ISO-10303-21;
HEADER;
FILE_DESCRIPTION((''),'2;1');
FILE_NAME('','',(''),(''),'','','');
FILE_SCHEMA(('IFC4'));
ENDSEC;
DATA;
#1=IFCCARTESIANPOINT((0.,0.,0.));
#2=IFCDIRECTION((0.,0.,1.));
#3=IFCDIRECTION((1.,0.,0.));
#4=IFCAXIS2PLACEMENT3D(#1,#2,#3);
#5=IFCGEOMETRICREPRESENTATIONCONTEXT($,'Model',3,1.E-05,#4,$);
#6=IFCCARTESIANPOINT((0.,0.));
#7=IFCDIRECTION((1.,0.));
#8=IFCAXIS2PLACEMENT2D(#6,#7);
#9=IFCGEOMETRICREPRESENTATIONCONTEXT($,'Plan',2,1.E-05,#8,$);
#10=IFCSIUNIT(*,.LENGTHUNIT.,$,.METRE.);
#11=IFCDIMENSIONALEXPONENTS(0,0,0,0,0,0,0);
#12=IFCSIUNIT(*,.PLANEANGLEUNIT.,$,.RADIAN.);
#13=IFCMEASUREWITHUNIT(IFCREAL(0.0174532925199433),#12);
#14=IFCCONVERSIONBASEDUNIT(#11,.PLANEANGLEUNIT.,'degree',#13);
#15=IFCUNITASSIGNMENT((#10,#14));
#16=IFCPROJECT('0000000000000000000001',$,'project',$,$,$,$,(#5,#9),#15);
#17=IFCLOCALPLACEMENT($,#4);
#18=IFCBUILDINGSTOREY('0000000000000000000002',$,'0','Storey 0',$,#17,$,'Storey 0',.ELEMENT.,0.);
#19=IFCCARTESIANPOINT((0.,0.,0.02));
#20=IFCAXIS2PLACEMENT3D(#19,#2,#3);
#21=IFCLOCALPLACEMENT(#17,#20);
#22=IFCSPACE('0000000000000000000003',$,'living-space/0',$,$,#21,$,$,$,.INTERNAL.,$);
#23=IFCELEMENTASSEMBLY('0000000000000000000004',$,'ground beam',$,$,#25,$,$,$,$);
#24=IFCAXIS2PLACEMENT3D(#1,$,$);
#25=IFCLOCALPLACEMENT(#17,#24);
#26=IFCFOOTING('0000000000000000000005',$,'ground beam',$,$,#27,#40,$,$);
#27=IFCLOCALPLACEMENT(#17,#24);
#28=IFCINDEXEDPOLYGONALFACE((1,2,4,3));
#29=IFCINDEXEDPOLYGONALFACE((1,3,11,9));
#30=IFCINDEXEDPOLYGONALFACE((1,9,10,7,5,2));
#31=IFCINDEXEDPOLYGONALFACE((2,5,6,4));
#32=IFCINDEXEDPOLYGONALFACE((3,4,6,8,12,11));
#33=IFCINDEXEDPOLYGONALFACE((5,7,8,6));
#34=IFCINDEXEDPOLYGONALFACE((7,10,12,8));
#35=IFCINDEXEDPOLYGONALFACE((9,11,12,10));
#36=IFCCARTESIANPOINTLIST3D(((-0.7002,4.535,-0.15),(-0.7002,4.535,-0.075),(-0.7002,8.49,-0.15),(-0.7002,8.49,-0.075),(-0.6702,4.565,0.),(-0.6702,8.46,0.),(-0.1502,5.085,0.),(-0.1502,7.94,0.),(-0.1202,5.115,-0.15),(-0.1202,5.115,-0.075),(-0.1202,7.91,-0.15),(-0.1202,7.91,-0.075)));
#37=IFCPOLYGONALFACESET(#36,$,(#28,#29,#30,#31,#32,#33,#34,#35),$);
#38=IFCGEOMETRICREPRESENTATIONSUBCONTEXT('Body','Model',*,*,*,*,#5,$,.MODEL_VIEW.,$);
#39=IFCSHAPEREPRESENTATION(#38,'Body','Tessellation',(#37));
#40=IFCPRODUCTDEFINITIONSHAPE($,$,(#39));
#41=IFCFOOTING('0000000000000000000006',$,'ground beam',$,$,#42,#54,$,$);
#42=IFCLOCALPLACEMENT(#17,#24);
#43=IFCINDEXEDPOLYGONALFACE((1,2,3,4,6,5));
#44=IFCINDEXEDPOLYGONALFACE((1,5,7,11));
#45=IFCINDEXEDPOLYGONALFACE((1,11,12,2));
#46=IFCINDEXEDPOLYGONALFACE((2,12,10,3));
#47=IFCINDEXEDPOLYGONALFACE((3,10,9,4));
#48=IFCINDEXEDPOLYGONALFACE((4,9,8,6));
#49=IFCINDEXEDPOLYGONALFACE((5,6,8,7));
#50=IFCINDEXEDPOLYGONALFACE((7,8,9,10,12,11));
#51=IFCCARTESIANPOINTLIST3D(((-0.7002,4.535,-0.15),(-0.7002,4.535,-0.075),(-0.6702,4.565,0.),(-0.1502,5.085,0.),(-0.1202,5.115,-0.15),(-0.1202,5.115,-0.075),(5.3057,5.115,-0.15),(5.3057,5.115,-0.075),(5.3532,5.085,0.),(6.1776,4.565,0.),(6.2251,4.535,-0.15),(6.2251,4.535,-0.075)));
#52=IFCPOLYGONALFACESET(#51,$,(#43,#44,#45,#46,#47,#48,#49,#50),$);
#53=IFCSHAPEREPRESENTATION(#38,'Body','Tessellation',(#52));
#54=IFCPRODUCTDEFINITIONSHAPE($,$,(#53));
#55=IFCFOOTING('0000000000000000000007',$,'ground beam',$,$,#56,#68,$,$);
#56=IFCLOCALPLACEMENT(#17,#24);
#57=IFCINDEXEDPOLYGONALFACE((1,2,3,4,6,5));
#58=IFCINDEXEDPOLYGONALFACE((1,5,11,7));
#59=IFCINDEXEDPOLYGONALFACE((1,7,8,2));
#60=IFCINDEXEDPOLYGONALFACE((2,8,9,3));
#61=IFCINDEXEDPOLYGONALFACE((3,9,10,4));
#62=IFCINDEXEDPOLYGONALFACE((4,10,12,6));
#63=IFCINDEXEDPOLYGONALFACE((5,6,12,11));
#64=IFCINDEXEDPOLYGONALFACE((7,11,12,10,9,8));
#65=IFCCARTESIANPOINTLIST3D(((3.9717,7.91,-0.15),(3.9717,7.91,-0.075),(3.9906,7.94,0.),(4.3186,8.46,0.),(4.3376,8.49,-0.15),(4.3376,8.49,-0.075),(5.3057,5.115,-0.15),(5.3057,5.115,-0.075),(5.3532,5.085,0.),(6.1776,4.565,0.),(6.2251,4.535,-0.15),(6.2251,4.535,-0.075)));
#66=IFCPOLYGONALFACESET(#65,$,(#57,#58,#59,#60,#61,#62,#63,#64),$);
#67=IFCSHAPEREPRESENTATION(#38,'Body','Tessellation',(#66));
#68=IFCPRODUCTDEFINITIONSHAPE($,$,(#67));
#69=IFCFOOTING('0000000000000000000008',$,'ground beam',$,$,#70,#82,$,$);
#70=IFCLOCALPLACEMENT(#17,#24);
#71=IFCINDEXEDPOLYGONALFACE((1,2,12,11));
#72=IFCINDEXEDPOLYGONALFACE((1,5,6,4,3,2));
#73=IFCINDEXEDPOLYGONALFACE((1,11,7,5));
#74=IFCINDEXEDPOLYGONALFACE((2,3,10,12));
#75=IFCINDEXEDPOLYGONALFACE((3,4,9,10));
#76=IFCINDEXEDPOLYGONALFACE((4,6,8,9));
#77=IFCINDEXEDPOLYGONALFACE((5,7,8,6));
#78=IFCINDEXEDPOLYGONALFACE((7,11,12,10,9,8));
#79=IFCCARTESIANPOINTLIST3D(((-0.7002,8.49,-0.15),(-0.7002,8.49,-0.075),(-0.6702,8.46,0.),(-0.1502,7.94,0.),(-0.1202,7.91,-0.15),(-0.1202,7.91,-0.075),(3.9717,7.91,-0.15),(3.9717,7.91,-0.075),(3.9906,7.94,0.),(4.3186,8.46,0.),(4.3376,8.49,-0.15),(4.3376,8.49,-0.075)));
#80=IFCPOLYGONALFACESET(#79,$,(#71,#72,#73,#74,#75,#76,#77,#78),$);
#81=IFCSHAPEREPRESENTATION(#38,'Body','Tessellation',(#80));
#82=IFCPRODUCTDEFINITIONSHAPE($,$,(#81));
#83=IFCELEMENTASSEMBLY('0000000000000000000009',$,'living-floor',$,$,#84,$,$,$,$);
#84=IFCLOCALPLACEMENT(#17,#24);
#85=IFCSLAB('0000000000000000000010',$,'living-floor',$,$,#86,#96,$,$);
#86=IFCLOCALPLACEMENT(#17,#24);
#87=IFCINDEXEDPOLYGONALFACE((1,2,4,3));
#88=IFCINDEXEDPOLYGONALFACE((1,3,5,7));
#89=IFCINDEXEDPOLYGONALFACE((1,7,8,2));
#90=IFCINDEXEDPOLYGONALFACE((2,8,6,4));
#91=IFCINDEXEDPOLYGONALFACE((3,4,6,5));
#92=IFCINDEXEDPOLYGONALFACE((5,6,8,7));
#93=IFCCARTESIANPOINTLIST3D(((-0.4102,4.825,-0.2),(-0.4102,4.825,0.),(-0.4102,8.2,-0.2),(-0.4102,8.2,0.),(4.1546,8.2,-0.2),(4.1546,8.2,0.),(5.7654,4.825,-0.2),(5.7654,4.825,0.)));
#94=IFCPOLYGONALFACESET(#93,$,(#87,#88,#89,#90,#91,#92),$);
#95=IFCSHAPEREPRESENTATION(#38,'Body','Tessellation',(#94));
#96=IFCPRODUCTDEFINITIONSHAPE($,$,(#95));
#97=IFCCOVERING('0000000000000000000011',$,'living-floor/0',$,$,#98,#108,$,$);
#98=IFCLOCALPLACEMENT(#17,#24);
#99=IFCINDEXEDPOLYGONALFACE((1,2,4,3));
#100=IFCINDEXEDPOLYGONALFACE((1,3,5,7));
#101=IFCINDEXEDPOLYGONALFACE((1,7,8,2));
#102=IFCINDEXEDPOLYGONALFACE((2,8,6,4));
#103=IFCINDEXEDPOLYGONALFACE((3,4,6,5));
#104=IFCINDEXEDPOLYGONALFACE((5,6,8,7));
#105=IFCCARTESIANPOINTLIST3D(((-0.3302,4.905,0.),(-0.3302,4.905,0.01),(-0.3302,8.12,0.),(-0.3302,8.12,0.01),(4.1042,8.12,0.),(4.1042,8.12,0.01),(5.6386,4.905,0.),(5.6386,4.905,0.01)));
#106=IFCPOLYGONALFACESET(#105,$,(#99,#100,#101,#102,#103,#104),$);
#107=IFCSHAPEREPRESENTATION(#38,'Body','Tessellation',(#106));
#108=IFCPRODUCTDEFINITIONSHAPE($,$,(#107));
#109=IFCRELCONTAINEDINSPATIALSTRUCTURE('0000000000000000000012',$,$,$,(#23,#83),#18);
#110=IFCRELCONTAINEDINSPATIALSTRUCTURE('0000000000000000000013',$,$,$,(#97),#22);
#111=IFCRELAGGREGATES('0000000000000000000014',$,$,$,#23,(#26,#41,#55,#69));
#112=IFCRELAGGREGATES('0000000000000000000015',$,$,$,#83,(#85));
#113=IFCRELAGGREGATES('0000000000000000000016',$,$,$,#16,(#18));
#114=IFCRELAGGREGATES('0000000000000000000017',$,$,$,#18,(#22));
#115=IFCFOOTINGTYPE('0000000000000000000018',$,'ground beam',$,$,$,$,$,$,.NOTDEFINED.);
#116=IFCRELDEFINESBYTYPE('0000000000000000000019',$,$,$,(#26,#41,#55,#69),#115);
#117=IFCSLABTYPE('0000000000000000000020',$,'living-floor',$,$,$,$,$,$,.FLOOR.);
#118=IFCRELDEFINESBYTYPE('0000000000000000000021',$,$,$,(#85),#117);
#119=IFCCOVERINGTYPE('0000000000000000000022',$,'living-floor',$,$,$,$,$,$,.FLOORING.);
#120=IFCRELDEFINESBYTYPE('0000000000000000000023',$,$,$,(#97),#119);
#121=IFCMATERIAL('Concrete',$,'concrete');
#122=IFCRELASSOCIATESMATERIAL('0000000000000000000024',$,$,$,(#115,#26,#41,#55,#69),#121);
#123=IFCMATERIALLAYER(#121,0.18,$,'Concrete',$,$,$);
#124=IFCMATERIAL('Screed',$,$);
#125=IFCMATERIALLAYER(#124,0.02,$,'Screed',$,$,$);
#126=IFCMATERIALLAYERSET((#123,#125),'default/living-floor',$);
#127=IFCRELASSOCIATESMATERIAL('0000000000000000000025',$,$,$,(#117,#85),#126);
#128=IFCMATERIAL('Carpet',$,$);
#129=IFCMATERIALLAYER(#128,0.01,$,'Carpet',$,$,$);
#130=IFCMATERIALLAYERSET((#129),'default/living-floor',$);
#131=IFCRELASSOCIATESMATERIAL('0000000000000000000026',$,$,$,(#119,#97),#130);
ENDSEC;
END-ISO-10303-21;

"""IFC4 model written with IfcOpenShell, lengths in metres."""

from ifc_helpers import new_model, entity, si_unit, converted_unit, frame, origin, origin_with_axes, origin_2d_with_axis, place, context, subcontext, project, spatial, polyline, outline, extrude, clip, halfspace, material, layer, layer_set, layer_usage, material_profile, profile_set, profile_usage, type_object, element, aggregate, save


model = new_model("IFC4")

# Units and contexts
model_context = context("Model", 3, precision=1e-05, world=origin_with_axes())
plan_context = context("Plan", 2, precision=1e-05, world=origin_2d_with_axis())
body_context = subcontext(model_context, "Body", "Model", "MODEL_VIEW")
ifc_project = project(units=[si_unit("LENGTHUNIT", "METRE"), converted_unit("PLANEANGLEUNIT", "degree", entity("IfcReal", 0.0174532925199433), si_unit("PLANEANGLEUNIT", "RADIAN"), dimensions=[0, 0, 0, 0, 0, 0, 0])], contexts=[model_context, plan_context])

# Storey
storey_placement = place(None, origin_with_axes())
storey = spatial("IfcBuildingStorey", under=ifc_project, at=storey_placement, Name="0", Description="Storey 0", LongName="Storey 0", CompositionType="ELEMENT", Elevation=0.0)

# Element assembly, footings
assembly_1_placement = place(storey_placement, origin_with_axes())
assembly_1 = element("IfcElementAssembly", 1, at=assembly_1_placement, inside=storey, Name="ground beam")
ifc_material_1 = material(Name="Concrete", Category="concrete")
ifc_material_profile = material_profile(ifc_material_1, outline(polyline([(-0.26, 0.0), (-0.29, -0.075), (-0.29, -0.15), (0.29, -0.15), (0.29, -0.075), (0.26, 0.0), (-0.26, 0.0)])))
ifc_profile_set = profile_set([ifc_material_profile])
ifc_profile_usage_1 = profile_usage(ifc_profile_set)
footing_type = type_object("IfcFootingType", Name="ground beam", PredefinedType="NOTDEFINED", material=ifc_profile_set)
footing_1_placement = place(assembly_1_placement, frame((-0.4102, 3.825, 0.0), z_axis=(0.0, 1.0, 0.0), x_axis=(-1.0, 0.0, 0.0)))
footing_1 = element("IfcFooting", 2, at=footing_1_placement, type_object=footing_type, material=ifc_profile_usage_1, Name="ground beam", context=body_context, shape_type="Clipping", body=[
    clip(clip(extrude(outline(polyline([(-0.26, 0.0), (-0.29, -0.075), (-0.29, -0.15), (0.29, -0.15), (0.29, -0.075), (0.26, 0.0), (-0.26, 0.0)])), origin_with_axes(), (0.0, 0.0, 1.0), 5.375), halfspace(frame((0.0, 0.0, 1.0), z_axis=(-0.707107, 0.0, -0.707107), x_axis=(0.0, 1.0, 0.0)), False)), halfspace(frame((0.0, 0.0, 4.375), z_axis=(-0.707107, 0.0, 0.707107), x_axis=(0.0, 1.0, 0.0)), False)),
])
ifc_profile_usage_2 = profile_usage(ifc_profile_set)
footing_2_placement = place(assembly_1_placement, frame((6.7654, 4.825, 0.0), z_axis=(-1.0, 0.0, 0.0), x_axis=(0.0, -1.0, 0.0)))
footing_2 = element("IfcFooting", 3, at=footing_2_placement, type_object=footing_type, material=ifc_profile_usage_2, Name="ground beam", context=body_context, shape_type="Clipping", body=[
    clip(clip(extrude(outline(polyline([(-0.26, 0.0), (-0.29, -0.075), (-0.29, -0.15), (0.29, -0.15), (0.29, -0.075), (0.26, 0.0), (-0.26, 0.0)])), origin_with_axes(), (0.0, 0.0, 1.0), 8.1756), halfspace(frame((0.0, 0.0, 1.0), z_axis=(-0.845791, 0.0, -0.533515), x_axis=(0.0, 1.0, 0.0)), False)), halfspace(frame((0.0, 0.0, 7.1756), z_axis=(-0.707107, 0.0, 0.707107), x_axis=(0.0, 1.0, 0.0)), False)),
])
ifc_profile_usage_3 = profile_usage(ifc_profile_set)
footing_3_placement = place(assembly_1_placement, frame((3.7239, 9.1025, 0.0), z_axis=(0.430724, -0.902484, 0.0), x_axis=(0.902484, 0.430724, 0.0)))
footing_3 = element("IfcFooting", 4, at=footing_3_placement, type_object=footing_type, material=ifc_profile_usage_3, Name="ground beam", context=body_context, shape_type="Clipping", body=[
    clip(clip(extrude(outline(polyline([(-0.26, 0.0), (-0.29, -0.075), (-0.29, -0.15), (0.29, -0.15), (0.29, -0.075), (0.26, 0.0), (-0.26, 0.0)])), origin_with_axes(), (0.0, 0.0, 1.0), 5.7397), halfspace(frame((0.0, 0.0, 1.0), z_axis=(-0.533515, 0.0, -0.845791), x_axis=(0.0, 1.0, 0.0)), False)), halfspace(frame((0.0, 0.0, 4.7397), z_axis=(-0.845791, 0.0, 0.533515), x_axis=(0.0, 1.0, 0.0)), False)),
])
ifc_profile_usage_4 = profile_usage(ifc_profile_set)
footing_4_placement = place(assembly_1_placement, frame((-1.4102, 8.2, 0.0), z_axis=(1.0, 0.0, 0.0), x_axis=(0.0, 1.0, 0.0)))
footing_4 = element("IfcFooting", 5, at=footing_4_placement, type_object=footing_type, material=ifc_profile_usage_4, Name="ground beam", context=body_context, shape_type="Clipping", body=[
    clip(clip(extrude(outline(polyline([(-0.26, 0.0), (-0.29, -0.075), (-0.29, -0.15), (0.29, -0.15), (0.29, -0.075), (0.26, 0.0), (-0.26, 0.0)])), origin_with_axes(), (0.0, 0.0, 1.0), 6.5648), halfspace(frame((0.0, 0.0, 1.0), z_axis=(-0.707107, 0.0, -0.707107), x_axis=(0.0, 1.0, 0.0)), False)), halfspace(frame((0.0, 0.0, 5.5648), z_axis=(-0.533515, 0.0, 0.845791), x_axis=(0.0, 1.0, 0.0)), False)),
])
aggregate(assembly_1, [footing_1, footing_2, footing_3, footing_4])

# Element assembly, slab
assembly_2_placement = place(storey_placement, origin_with_axes())
assembly_2 = element("IfcElementAssembly", 6, at=assembly_2_placement, inside=storey, Name="living-floor")
ifc_layer_1 = layer(ifc_material_1, 0.18, Name="Concrete")
ifc_material_2 = material(Name="Screed")
ifc_layer_2 = layer(ifc_material_2, 0.02, Name="Screed")
ifc_layer_set_1 = layer_set([ifc_layer_1, ifc_layer_2], Name="default/living-floor")
ifc_layer_usage_1 = layer_usage(ifc_layer_set_1, "AXIS3", "POSITIVE", 0.0)
slab_type = type_object("IfcSlabType", Name="living-floor", PredefinedType="FLOOR", material=ifc_layer_set_1)
slab_placement = place(assembly_2_placement, frame((4.1546, 8.2, -0.2), z_axis=(0.0, 0.0, -1.0), x_axis=(0.0, 1.0, 0.0)))
slab = element("IfcSlab", 7, at=slab_placement, type_object=slab_type, material=ifc_layer_usage_1, Name="living-floor", context=body_context, shape_type="SweptSolid", body=[
    extrude(outline(polyline([(0.0, 0.0), (-3.375, 1.6108), (-3.375, -4.5648), (0.0, -4.5648), (0.0, 0.0)])), origin(), (0.0, 0.0, -1.0), 0.2),
])
aggregate(assembly_2, [slab])

# Shared definitions
space_placement = place(storey_placement, frame((0.0, 0.0, 0.02), z_axis=(0.0, 0.0, 1.0), x_axis=(1.0, 0.0, 0.0)))
space = spatial("IfcSpace", under=storey, at=space_placement, Name="living-space/0", PredefinedType="INTERNAL")

# Covering
ifc_material_3 = material(Name="Carpet")
ifc_layer_3 = layer(ifc_material_3, 0.01, Name="Carpet")
ifc_layer_set_2 = layer_set([ifc_layer_3], Name="default/living-floor")
ifc_layer_usage_2 = layer_usage(ifc_layer_set_2, "AXIS2", "POSITIVE", 0.0)
covering_type = type_object("IfcCoveringType", Name="living-floor", PredefinedType="FLOORING", material=ifc_layer_set_2)
covering_placement = place(space_placement, frame((0.0, 0.0, -0.02), z_axis=(0.0, 0.0, 1.0), x_axis=(1.0, 0.0, 0.0)))
element("IfcCovering", 8, at=covering_placement, inside=space, type_object=covering_type, material=ifc_layer_usage_2, Name="living-floor/0", context=body_context, shape_type="SweptSolid", body=[
    extrude(outline(polyline([(4.1042, 8.12), (-0.3302, 8.12), (-0.3302, 4.905), (5.6386, 4.905), (4.1042, 8.12)])), origin_with_axes(), (0.0, 0.0, 1.0), 0.01),
])

save(model, "model.ifc")
